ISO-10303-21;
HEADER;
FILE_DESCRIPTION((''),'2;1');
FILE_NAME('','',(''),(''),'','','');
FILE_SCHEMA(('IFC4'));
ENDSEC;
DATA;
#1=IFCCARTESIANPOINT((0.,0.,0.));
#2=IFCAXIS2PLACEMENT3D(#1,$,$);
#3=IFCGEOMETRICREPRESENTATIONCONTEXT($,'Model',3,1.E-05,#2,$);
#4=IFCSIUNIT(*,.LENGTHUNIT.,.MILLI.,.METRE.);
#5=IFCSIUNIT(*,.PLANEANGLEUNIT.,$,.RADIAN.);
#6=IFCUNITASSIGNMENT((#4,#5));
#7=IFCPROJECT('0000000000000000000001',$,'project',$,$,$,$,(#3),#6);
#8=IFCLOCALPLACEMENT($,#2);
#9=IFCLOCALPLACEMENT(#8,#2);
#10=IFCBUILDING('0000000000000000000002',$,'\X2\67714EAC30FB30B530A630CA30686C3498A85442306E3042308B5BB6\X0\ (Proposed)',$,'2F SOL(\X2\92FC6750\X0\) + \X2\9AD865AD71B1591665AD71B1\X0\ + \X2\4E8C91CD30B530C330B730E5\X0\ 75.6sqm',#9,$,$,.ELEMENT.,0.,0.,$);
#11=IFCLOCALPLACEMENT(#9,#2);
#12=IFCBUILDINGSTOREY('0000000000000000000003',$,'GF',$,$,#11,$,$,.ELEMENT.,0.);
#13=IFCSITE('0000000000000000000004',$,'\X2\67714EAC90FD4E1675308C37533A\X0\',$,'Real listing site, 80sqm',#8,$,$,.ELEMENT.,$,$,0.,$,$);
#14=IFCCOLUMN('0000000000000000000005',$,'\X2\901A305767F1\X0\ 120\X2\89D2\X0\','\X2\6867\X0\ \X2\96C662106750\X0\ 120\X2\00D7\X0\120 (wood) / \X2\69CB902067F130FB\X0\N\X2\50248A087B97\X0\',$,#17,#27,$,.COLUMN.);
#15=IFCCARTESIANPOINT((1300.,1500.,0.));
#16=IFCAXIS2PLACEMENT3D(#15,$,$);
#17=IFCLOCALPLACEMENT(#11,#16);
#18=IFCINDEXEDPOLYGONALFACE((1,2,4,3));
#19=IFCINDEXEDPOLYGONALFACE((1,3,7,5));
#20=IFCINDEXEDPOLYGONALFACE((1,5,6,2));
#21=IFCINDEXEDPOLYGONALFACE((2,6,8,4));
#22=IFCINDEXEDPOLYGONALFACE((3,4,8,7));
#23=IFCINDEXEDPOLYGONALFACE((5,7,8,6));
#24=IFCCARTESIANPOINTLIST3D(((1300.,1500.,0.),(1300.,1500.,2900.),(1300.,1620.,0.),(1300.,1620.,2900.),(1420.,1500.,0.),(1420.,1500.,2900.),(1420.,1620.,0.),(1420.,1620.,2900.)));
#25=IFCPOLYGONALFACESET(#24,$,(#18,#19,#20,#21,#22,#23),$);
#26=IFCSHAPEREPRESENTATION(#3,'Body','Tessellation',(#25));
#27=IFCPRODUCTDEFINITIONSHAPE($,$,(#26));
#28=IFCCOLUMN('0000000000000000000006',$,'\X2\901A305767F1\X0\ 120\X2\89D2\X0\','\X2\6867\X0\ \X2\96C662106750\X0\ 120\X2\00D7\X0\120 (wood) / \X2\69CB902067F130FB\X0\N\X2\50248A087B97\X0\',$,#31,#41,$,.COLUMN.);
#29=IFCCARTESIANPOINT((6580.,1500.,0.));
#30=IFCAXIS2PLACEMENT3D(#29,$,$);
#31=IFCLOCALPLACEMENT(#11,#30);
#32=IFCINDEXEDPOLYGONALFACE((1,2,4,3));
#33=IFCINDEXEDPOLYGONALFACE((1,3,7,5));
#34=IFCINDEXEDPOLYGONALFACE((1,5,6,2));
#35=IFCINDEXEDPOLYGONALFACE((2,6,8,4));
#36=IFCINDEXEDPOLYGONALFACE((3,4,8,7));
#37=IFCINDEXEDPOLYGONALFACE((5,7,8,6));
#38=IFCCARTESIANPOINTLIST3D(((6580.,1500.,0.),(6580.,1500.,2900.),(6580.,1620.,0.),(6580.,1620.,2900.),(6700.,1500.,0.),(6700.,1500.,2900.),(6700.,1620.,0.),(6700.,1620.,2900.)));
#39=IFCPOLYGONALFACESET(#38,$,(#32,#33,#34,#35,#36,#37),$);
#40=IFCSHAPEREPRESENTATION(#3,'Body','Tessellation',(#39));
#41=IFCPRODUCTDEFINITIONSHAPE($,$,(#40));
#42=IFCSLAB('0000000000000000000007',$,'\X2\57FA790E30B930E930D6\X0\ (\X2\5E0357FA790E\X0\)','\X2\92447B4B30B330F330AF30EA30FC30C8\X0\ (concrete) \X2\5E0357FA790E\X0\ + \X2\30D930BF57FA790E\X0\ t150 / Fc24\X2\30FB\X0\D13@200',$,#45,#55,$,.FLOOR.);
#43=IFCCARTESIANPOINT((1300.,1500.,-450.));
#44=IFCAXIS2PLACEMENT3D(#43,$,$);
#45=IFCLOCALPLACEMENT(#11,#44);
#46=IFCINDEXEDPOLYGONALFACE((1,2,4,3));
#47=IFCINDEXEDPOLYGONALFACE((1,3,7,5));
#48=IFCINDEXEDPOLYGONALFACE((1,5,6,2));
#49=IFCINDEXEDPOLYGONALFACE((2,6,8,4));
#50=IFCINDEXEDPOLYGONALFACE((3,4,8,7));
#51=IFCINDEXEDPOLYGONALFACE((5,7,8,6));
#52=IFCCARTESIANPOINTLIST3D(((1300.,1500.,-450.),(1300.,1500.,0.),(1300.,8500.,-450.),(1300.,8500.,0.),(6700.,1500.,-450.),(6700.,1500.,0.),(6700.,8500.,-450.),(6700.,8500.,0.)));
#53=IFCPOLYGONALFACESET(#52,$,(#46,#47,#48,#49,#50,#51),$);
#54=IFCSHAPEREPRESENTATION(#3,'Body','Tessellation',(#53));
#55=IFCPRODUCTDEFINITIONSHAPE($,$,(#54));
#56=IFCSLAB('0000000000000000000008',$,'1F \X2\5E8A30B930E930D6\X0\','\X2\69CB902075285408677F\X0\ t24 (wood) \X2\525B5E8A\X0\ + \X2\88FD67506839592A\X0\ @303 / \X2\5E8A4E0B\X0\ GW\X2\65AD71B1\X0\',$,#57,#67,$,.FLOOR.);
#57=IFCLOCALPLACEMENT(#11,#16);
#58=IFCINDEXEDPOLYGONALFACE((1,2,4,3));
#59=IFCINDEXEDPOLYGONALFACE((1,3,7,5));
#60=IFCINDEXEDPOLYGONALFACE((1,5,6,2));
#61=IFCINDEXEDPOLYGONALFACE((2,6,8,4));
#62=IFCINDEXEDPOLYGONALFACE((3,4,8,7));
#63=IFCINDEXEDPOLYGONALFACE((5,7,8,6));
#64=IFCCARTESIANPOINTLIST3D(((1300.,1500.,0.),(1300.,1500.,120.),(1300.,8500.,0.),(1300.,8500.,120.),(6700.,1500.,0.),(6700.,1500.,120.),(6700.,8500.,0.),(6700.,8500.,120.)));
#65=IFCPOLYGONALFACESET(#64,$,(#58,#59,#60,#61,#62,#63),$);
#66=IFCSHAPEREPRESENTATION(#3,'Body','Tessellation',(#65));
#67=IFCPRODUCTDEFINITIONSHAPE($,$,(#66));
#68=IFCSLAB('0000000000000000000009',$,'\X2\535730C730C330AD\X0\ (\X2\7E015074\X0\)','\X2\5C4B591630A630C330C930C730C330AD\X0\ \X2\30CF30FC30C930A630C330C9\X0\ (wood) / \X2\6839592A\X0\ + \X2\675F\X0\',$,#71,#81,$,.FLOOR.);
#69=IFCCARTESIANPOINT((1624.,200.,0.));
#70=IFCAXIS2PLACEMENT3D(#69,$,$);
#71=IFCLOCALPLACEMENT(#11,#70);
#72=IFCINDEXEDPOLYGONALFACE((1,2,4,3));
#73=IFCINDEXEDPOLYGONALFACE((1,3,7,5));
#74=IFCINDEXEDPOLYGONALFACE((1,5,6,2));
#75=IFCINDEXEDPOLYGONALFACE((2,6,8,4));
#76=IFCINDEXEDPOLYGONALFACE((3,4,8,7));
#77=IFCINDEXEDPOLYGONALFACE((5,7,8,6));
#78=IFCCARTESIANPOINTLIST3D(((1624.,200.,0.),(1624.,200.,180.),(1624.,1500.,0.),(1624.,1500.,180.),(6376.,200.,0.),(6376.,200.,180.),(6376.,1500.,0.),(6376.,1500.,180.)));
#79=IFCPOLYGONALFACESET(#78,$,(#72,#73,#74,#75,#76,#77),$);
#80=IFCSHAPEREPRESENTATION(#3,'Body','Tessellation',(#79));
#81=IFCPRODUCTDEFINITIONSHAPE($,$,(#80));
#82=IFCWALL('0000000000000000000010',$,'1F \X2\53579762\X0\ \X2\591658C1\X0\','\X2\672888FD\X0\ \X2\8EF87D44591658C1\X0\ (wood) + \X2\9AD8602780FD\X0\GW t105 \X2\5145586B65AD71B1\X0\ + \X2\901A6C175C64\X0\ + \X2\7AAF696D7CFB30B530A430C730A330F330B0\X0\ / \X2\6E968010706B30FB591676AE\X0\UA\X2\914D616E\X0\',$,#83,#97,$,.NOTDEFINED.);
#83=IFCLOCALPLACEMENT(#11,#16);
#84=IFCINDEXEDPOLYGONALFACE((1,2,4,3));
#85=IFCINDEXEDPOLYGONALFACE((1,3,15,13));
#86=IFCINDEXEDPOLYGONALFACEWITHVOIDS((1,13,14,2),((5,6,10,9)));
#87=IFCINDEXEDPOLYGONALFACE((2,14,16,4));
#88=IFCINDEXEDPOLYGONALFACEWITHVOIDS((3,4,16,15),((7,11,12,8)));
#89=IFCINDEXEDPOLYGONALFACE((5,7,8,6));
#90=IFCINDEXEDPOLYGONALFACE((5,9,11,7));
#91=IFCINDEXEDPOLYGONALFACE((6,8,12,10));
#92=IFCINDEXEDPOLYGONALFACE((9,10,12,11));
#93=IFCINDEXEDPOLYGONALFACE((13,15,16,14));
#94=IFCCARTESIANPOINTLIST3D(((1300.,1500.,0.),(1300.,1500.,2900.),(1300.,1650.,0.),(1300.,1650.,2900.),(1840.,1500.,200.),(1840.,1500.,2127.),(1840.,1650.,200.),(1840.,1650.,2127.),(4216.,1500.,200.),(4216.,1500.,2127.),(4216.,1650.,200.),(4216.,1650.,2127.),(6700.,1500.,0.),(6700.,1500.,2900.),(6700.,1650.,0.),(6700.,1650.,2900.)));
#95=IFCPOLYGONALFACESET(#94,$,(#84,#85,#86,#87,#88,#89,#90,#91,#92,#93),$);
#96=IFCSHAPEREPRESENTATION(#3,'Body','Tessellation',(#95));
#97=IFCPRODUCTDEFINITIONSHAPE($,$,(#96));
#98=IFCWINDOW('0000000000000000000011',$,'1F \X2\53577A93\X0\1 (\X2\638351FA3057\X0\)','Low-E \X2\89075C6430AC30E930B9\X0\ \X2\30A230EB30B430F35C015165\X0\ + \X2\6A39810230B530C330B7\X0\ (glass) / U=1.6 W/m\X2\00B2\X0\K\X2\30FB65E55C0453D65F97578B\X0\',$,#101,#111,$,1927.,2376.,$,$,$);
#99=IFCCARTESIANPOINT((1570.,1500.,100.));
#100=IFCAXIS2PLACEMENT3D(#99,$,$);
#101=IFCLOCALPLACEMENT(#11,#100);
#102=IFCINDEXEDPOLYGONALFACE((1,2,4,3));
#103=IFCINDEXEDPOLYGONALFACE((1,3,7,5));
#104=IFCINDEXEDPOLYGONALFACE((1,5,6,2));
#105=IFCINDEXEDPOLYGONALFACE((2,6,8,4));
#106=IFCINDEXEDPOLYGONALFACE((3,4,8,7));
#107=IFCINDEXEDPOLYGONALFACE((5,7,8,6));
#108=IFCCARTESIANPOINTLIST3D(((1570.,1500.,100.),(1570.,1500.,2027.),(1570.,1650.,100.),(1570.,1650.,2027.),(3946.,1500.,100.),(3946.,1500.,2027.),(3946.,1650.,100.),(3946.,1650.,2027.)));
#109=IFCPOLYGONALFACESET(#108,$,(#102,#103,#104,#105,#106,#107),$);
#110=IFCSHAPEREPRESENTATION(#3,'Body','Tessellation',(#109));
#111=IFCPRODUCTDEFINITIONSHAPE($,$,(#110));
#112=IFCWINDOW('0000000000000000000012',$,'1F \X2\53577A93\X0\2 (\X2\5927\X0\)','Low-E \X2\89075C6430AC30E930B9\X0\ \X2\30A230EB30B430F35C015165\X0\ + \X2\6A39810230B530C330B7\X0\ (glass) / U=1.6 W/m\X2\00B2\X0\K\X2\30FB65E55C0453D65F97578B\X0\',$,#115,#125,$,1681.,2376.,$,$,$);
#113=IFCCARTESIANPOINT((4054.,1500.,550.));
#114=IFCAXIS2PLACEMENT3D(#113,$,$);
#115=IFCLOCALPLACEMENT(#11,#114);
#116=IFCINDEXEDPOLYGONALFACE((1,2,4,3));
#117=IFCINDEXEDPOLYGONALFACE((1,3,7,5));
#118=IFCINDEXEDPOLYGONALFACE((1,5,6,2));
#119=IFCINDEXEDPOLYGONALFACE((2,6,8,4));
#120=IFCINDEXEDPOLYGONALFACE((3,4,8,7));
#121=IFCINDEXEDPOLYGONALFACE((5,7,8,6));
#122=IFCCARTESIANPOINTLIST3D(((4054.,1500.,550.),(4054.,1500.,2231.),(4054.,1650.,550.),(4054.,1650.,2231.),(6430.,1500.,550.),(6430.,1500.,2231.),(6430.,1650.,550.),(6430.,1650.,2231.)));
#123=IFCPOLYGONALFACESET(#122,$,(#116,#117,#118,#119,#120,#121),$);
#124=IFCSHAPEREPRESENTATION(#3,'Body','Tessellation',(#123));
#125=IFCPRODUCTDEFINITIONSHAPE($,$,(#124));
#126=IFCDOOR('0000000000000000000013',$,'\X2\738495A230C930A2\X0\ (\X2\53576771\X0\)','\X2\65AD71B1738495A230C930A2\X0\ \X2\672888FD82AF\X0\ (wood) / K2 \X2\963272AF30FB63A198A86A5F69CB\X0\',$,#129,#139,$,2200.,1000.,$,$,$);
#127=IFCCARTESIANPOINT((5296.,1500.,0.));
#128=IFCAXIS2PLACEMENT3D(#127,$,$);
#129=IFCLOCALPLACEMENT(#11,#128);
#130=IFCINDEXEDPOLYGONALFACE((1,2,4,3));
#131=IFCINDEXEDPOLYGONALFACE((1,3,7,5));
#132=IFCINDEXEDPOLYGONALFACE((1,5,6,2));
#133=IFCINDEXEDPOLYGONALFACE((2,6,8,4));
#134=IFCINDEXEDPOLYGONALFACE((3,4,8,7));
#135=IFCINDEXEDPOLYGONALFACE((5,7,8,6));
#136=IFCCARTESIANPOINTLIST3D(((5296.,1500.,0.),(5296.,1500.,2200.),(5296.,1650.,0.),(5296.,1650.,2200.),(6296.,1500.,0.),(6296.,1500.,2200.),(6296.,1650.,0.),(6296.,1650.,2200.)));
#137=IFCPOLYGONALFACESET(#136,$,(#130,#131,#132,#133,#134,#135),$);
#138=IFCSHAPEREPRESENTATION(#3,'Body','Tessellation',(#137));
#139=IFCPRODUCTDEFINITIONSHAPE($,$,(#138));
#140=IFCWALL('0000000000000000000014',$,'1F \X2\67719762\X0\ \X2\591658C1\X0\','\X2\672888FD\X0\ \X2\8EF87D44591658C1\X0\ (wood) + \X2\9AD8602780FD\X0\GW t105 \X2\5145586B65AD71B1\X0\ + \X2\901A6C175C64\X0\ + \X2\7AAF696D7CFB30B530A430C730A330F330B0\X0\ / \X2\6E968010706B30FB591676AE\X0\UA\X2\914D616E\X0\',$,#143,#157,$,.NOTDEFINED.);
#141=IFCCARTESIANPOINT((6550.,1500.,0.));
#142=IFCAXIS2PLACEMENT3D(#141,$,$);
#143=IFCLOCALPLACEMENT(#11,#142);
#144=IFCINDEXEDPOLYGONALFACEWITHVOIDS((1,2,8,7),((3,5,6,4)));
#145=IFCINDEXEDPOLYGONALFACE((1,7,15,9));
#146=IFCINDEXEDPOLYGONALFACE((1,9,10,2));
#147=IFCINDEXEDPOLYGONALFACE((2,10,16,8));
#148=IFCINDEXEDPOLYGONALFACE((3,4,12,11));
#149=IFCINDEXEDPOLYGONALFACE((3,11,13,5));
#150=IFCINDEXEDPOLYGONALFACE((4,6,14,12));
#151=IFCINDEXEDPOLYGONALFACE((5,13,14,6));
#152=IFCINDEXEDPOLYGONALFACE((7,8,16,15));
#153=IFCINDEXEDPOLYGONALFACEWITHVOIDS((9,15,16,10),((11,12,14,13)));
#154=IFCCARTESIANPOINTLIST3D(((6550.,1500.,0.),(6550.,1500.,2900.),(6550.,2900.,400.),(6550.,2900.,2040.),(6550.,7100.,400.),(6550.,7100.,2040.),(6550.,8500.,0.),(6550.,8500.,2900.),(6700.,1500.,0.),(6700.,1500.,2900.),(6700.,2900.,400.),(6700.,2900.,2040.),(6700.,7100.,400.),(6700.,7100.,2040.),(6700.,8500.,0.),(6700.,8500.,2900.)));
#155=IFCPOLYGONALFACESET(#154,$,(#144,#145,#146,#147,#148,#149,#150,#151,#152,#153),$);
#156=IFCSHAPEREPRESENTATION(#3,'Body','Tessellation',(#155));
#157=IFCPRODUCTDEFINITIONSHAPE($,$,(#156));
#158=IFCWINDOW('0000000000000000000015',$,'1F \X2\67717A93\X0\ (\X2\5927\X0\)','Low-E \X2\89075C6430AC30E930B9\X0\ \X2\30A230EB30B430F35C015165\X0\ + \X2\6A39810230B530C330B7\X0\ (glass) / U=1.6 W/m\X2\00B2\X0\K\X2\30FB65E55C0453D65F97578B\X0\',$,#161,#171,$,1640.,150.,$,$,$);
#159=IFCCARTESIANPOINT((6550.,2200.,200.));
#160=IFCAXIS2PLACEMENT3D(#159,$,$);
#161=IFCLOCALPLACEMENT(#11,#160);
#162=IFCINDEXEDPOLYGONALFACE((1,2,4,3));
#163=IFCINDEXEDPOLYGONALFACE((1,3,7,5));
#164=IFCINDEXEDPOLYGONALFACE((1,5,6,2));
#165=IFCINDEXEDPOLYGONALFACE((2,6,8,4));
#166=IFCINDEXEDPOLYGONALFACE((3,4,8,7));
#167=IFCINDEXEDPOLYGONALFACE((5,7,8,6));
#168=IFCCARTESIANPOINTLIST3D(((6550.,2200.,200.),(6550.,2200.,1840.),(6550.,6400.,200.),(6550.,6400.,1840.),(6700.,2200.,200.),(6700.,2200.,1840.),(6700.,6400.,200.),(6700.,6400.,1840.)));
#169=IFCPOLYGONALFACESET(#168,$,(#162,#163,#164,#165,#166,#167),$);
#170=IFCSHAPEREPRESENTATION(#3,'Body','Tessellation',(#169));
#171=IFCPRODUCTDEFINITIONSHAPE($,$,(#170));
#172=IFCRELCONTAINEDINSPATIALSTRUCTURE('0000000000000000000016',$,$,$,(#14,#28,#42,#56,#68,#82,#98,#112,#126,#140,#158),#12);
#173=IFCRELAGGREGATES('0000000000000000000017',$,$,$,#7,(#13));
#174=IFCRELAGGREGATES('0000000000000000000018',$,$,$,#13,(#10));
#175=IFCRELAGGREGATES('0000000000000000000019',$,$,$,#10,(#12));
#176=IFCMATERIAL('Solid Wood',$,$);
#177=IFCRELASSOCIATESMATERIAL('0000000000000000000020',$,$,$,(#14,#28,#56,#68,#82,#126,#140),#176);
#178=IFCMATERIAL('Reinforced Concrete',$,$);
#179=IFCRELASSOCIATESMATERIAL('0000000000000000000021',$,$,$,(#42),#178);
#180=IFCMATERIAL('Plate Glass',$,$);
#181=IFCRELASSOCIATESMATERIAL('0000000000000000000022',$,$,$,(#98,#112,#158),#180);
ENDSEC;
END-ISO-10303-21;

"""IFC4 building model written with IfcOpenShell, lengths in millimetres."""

from ifc_helpers import new_model, si_unit, frame, frame_2d, origin, place, context, project, spatial, rectangle, extrude, material, element, fill, save


model = new_model("IFC4")

# Units and contexts
model_context = context("Model", 3, precision=1e-05, world=origin())
ifc_project = project(units=[si_unit("LENGTHUNIT", "METRE", prefix="MILLI"), si_unit("PLANEANGLEUNIT", "RADIAN")], contexts=[model_context])

# Site, building, storey
site_placement = place(None, origin())
site = spatial("IfcSite", under=ifc_project, at=site_placement, Name="東京都世田谷区", ObjectType="Real listing site, 80sqm", CompositionType="ELEMENT", RefElevation=0.0)
building_placement = place(site_placement, origin())
building = spatial("IfcBuilding", under=site, at=building_placement, Name="東京・サウナと水風呂のある家 (Proposed)", ObjectType="2F SOL(鋼材) + 高断熱外断熱 + 二重サッシュ 75.6sqm", CompositionType="ELEMENT", ElevationOfRefHeight=0.0, ElevationOfTerrain=0.0)
storey_placement = place(building_placement, origin())
storey = spatial("IfcBuildingStorey", under=building, at=storey_placement, Name="GF", CompositionType="ELEMENT", Elevation=0.0)

# Columns
ifc_material_1 = material(Name="Solid Wood")
column_1_placement = place(storey_placement, frame((1300.0, 1500.0, 0.0)))
element("IfcColumn", 1, at=column_1_placement, inside=storey, material=ifc_material_1, Name="通し柱 120角", Description="桧 集成材 120×120 (wood) / 構造柱・N値計算", PredefinedType="COLUMN", context=model_context, shape_type="SweptSolid", body=[
    extrude(rectangle(XDim=120.0, YDim=120.0, at=frame_2d((60.0, 60.0))), frame((1300.0, 1500.0, 0.0)), (0.0, 0.0, 1.0), 2900.0),
])
column_2_placement = place(storey_placement, frame((6580.0, 1500.0, 0.0)))
element("IfcColumn", 2, at=column_2_placement, inside=storey, material=ifc_material_1, Name="通し柱 120角", Description="桧 集成材 120×120 (wood) / 構造柱・N値計算", PredefinedType="COLUMN", context=model_context, shape_type="SweptSolid", body=[
    extrude(rectangle(XDim=120.0, YDim=120.0, at=frame_2d((60.0, 60.0))), frame((6580.0, 1500.0, 0.0)), (0.0, 0.0, 1.0), 2900.0),
])

# Slabs
ifc_material_2 = material(Name="Reinforced Concrete")
slab_1_placement = place(storey_placement, frame((1300.0, 1500.0, -450.0)))
element("IfcSlab", 3, at=slab_1_placement, inside=storey, material=ifc_material_2, Name="基礎スラブ (布基礎)", Description="鉄筋コンクリート (concrete) 布基礎 + ベタ基礎 t150 / Fc24・D13@200", PredefinedType="FLOOR", context=model_context, shape_type="SweptSolid", body=[
    extrude(rectangle(XDim=5400.0, YDim=7000.0, at=frame_2d((2700.0, 3500.0))), frame((1300.0, 1500.0, -450.0)), (0.0, 0.0, 1.0), 450.0),
])
slab_2_placement = place(storey_placement, frame((1300.0, 1500.0, 0.0)))
element("IfcSlab", 4, at=slab_2_placement, inside=storey, material=ifc_material_1, Name="1F 床スラブ", Description="構造用合板 t24 (wood) 剛床 + 製材根太 @303 / 床下 GW断熱", PredefinedType="FLOOR", context=model_context, shape_type="SweptSolid", body=[
    extrude(rectangle(XDim=5400.0, YDim=7000.0, at=frame_2d((2700.0, 3500.0))), frame((1300.0, 1500.0, 0.0)), (0.0, 0.0, 1.0), 120.0),
])
slab_3_placement = place(storey_placement, frame((1624.0, 200.0, 0.0)))
element("IfcSlab", 5, at=slab_3_placement, inside=storey, material=ifc_material_1, Name="南デッキ (縁側)", Description="屋外ウッドデッキ ハードウッド (wood) / 根太 + 束", PredefinedType="FLOOR", context=model_context, shape_type="SweptSolid", body=[
    extrude(rectangle(XDim=4752.0, YDim=1300.0, at=frame_2d((2376.0, 650.0))), frame((1624.0, 200.0, 0.0)), (0.0, 0.0, 1.0), 180.0),
])

# Wall, openings, windows, door
wall_1_placement = place(storey_placement, frame((1300.0, 1500.0, 0.0)))
wall_1 = element("IfcWall", 6, at=wall_1_placement, inside=storey, material=ifc_material_1, Name="1F 南面 外壁", Description="木製 軸組外壁 (wood) + 高性能GW t105 充填断熱 + 通気層 + 窯業系サイディング / 準耐火・外皮UA配慮", PredefinedType="NOTDEFINED", context=model_context, shape_type="SweptSolid", body=[
    extrude(rectangle(XDim=5400.0, YDim=150.0, at=frame_2d((2700.0, 75.0))), frame((1300.0, 1500.0, 0.0)), (0.0, 0.0, 1.0), 2900.0),
])
opening_1_placement = place(storey_placement, frame((1570.0, 1500.0, 100.0)))
opening_1 = element("IfcOpeningElement", 7, at=opening_1_placement, cuts=wall_1, PredefinedType="NOTDEFINED", context=model_context, shape_type="SweptSolid", body=[
    extrude(rectangle(XDim=2376.0, YDim=150.0, at=frame_2d((1188.0, 75.0))), frame((1570.0, 1500.0, 100.0)), (0.0, 0.0, 1.0), 1927.0),
])
opening_2_placement = place(storey_placement, frame((4054.0, 1500.0, 550.0)))
opening_2 = element("IfcOpeningElement", 8, at=opening_2_placement, cuts=wall_1, PredefinedType="NOTDEFINED", context=model_context, shape_type="SweptSolid", body=[
    extrude(rectangle(XDim=2376.0, YDim=150.0, at=frame_2d((1188.0, 75.0))), frame((4054.0, 1500.0, 550.0)), (0.0, 0.0, 1.0), 1681.0),
])
opening_3_placement = place(storey_placement, frame((5296.0, 1500.0, 0.0)))
opening_3 = element("IfcOpeningElement", 9, at=opening_3_placement, cuts=wall_1, PredefinedType="NOTDEFINED", context=model_context, shape_type="SweptSolid", body=[
    extrude(rectangle(XDim=1000.0, YDim=150.0, at=frame_2d((500.0, 75.0))), frame((5296.0, 1500.0, 0.0)), (0.0, 0.0, 1.0), 2200.0),
])
ifc_material_3 = material(Name="Plate Glass")
window_1_placement = place(storey_placement, frame((1570.0, 1500.0, 100.0)))
window_1 = element("IfcWindow", 10, at=window_1_placement, inside=storey, material=ifc_material_3, Name="1F 南窓1 (掃出し)", Description="Low-E 複層ガラス アルゴン封入 + 樹脂サッシ (glass) / U=1.6 W/m²K・日射取得型", OverallHeight=1927.0, OverallWidth=2376.0, context=model_context, shape_type="SweptSolid", body=[
    extrude(rectangle(XDim=2376.0, YDim=150.0, at=frame_2d((1188.0, 75.0))), frame((1570.0, 1500.0, 100.0)), (0.0, 0.0, 1.0), 1927.0),
])
fill(opening_1, window_1)
window_2_placement = place(storey_placement, frame((4054.0, 1500.0, 550.0)))
window_2 = element("IfcWindow", 11, at=window_2_placement, inside=storey, material=ifc_material_3, Name="1F 南窓2 (大)", Description="Low-E 複層ガラス アルゴン封入 + 樹脂サッシ (glass) / U=1.6 W/m²K・日射取得型", OverallHeight=1681.0, OverallWidth=2376.0, context=model_context, shape_type="SweptSolid", body=[
    extrude(rectangle(XDim=2376.0, YDim=150.0, at=frame_2d((1188.0, 75.0))), frame((4054.0, 1500.0, 550.0)), (0.0, 0.0, 1.0), 1681.0),
])
fill(opening_2, window_2)
door_placement = place(storey_placement, frame((5296.0, 1500.0, 0.0)))
door = element("IfcDoor", 12, at=door_placement, inside=storey, material=ifc_material_1, Name="玄関ドア (南東)", Description="断熱玄関ドア 木製芯 (wood) / K2 防犯・採風機構", OverallHeight=2200.0, OverallWidth=1000.0, context=model_context, shape_type="SweptSolid", body=[
    extrude(rectangle(XDim=1000.0, YDim=150.0, at=frame_2d((500.0, 75.0))), frame((5296.0, 1500.0, 0.0)), (0.0, 0.0, 1.0), 2200.0),
])
fill(opening_3, door)

# Wall, opening, window
wall_2_placement = place(storey_placement, frame((6550.0, 1500.0, 0.0)))
wall_2 = element("IfcWall", 13, at=wall_2_placement, inside=storey, material=ifc_material_1, Name="1F 東面 外壁", Description="木製 軸組外壁 (wood) + 高性能GW t105 充填断熱 + 通気層 + 窯業系サイディング / 準耐火・外皮UA配慮", PredefinedType="NOTDEFINED", context=model_context, shape_type="SweptSolid", body=[
    extrude(rectangle(XDim=150.0, YDim=7000.0, at=frame_2d((75.0, 3500.0))), frame((6550.0, 1500.0, 0.0)), (0.0, 0.0, 1.0), 2900.0),
])
opening_4_placement = place(storey_placement, frame((6550.0, 2200.0, 200.0)))
opening_4 = element("IfcOpeningElement", 14, at=opening_4_placement, cuts=wall_2, PredefinedType="NOTDEFINED", context=model_context, shape_type="SweptSolid", body=[
    extrude(rectangle(XDim=150.0, YDim=4200.0, at=frame_2d((75.0, 2100.0))), frame((6550.0, 2200.0, 200.0)), (0.0, 0.0, 1.0), 1640.0),
])
window_3_placement = place(storey_placement, frame((6550.0, 2200.0, 200.0)))
window_3 = element("IfcWindow", 15, at=window_3_placement, inside=storey, material=ifc_material_3, Name="1F 東窓 (大)", Description="Low-E 複層ガラス アルゴン封入 + 樹脂サッシ (glass) / U=1.6 W/m²K・日射取得型", OverallHeight=1640.0, OverallWidth=150.0, context=model_context, shape_type="SweptSolid", body=[
    extrude(rectangle(XDim=150.0, YDim=4200.0, at=frame_2d((75.0, 2100.0))), frame((6550.0, 2200.0, 200.0)), (0.0, 0.0, 1.0), 1640.0),
])
fill(opening_4, window_3)

save(model, "model.ifc")
